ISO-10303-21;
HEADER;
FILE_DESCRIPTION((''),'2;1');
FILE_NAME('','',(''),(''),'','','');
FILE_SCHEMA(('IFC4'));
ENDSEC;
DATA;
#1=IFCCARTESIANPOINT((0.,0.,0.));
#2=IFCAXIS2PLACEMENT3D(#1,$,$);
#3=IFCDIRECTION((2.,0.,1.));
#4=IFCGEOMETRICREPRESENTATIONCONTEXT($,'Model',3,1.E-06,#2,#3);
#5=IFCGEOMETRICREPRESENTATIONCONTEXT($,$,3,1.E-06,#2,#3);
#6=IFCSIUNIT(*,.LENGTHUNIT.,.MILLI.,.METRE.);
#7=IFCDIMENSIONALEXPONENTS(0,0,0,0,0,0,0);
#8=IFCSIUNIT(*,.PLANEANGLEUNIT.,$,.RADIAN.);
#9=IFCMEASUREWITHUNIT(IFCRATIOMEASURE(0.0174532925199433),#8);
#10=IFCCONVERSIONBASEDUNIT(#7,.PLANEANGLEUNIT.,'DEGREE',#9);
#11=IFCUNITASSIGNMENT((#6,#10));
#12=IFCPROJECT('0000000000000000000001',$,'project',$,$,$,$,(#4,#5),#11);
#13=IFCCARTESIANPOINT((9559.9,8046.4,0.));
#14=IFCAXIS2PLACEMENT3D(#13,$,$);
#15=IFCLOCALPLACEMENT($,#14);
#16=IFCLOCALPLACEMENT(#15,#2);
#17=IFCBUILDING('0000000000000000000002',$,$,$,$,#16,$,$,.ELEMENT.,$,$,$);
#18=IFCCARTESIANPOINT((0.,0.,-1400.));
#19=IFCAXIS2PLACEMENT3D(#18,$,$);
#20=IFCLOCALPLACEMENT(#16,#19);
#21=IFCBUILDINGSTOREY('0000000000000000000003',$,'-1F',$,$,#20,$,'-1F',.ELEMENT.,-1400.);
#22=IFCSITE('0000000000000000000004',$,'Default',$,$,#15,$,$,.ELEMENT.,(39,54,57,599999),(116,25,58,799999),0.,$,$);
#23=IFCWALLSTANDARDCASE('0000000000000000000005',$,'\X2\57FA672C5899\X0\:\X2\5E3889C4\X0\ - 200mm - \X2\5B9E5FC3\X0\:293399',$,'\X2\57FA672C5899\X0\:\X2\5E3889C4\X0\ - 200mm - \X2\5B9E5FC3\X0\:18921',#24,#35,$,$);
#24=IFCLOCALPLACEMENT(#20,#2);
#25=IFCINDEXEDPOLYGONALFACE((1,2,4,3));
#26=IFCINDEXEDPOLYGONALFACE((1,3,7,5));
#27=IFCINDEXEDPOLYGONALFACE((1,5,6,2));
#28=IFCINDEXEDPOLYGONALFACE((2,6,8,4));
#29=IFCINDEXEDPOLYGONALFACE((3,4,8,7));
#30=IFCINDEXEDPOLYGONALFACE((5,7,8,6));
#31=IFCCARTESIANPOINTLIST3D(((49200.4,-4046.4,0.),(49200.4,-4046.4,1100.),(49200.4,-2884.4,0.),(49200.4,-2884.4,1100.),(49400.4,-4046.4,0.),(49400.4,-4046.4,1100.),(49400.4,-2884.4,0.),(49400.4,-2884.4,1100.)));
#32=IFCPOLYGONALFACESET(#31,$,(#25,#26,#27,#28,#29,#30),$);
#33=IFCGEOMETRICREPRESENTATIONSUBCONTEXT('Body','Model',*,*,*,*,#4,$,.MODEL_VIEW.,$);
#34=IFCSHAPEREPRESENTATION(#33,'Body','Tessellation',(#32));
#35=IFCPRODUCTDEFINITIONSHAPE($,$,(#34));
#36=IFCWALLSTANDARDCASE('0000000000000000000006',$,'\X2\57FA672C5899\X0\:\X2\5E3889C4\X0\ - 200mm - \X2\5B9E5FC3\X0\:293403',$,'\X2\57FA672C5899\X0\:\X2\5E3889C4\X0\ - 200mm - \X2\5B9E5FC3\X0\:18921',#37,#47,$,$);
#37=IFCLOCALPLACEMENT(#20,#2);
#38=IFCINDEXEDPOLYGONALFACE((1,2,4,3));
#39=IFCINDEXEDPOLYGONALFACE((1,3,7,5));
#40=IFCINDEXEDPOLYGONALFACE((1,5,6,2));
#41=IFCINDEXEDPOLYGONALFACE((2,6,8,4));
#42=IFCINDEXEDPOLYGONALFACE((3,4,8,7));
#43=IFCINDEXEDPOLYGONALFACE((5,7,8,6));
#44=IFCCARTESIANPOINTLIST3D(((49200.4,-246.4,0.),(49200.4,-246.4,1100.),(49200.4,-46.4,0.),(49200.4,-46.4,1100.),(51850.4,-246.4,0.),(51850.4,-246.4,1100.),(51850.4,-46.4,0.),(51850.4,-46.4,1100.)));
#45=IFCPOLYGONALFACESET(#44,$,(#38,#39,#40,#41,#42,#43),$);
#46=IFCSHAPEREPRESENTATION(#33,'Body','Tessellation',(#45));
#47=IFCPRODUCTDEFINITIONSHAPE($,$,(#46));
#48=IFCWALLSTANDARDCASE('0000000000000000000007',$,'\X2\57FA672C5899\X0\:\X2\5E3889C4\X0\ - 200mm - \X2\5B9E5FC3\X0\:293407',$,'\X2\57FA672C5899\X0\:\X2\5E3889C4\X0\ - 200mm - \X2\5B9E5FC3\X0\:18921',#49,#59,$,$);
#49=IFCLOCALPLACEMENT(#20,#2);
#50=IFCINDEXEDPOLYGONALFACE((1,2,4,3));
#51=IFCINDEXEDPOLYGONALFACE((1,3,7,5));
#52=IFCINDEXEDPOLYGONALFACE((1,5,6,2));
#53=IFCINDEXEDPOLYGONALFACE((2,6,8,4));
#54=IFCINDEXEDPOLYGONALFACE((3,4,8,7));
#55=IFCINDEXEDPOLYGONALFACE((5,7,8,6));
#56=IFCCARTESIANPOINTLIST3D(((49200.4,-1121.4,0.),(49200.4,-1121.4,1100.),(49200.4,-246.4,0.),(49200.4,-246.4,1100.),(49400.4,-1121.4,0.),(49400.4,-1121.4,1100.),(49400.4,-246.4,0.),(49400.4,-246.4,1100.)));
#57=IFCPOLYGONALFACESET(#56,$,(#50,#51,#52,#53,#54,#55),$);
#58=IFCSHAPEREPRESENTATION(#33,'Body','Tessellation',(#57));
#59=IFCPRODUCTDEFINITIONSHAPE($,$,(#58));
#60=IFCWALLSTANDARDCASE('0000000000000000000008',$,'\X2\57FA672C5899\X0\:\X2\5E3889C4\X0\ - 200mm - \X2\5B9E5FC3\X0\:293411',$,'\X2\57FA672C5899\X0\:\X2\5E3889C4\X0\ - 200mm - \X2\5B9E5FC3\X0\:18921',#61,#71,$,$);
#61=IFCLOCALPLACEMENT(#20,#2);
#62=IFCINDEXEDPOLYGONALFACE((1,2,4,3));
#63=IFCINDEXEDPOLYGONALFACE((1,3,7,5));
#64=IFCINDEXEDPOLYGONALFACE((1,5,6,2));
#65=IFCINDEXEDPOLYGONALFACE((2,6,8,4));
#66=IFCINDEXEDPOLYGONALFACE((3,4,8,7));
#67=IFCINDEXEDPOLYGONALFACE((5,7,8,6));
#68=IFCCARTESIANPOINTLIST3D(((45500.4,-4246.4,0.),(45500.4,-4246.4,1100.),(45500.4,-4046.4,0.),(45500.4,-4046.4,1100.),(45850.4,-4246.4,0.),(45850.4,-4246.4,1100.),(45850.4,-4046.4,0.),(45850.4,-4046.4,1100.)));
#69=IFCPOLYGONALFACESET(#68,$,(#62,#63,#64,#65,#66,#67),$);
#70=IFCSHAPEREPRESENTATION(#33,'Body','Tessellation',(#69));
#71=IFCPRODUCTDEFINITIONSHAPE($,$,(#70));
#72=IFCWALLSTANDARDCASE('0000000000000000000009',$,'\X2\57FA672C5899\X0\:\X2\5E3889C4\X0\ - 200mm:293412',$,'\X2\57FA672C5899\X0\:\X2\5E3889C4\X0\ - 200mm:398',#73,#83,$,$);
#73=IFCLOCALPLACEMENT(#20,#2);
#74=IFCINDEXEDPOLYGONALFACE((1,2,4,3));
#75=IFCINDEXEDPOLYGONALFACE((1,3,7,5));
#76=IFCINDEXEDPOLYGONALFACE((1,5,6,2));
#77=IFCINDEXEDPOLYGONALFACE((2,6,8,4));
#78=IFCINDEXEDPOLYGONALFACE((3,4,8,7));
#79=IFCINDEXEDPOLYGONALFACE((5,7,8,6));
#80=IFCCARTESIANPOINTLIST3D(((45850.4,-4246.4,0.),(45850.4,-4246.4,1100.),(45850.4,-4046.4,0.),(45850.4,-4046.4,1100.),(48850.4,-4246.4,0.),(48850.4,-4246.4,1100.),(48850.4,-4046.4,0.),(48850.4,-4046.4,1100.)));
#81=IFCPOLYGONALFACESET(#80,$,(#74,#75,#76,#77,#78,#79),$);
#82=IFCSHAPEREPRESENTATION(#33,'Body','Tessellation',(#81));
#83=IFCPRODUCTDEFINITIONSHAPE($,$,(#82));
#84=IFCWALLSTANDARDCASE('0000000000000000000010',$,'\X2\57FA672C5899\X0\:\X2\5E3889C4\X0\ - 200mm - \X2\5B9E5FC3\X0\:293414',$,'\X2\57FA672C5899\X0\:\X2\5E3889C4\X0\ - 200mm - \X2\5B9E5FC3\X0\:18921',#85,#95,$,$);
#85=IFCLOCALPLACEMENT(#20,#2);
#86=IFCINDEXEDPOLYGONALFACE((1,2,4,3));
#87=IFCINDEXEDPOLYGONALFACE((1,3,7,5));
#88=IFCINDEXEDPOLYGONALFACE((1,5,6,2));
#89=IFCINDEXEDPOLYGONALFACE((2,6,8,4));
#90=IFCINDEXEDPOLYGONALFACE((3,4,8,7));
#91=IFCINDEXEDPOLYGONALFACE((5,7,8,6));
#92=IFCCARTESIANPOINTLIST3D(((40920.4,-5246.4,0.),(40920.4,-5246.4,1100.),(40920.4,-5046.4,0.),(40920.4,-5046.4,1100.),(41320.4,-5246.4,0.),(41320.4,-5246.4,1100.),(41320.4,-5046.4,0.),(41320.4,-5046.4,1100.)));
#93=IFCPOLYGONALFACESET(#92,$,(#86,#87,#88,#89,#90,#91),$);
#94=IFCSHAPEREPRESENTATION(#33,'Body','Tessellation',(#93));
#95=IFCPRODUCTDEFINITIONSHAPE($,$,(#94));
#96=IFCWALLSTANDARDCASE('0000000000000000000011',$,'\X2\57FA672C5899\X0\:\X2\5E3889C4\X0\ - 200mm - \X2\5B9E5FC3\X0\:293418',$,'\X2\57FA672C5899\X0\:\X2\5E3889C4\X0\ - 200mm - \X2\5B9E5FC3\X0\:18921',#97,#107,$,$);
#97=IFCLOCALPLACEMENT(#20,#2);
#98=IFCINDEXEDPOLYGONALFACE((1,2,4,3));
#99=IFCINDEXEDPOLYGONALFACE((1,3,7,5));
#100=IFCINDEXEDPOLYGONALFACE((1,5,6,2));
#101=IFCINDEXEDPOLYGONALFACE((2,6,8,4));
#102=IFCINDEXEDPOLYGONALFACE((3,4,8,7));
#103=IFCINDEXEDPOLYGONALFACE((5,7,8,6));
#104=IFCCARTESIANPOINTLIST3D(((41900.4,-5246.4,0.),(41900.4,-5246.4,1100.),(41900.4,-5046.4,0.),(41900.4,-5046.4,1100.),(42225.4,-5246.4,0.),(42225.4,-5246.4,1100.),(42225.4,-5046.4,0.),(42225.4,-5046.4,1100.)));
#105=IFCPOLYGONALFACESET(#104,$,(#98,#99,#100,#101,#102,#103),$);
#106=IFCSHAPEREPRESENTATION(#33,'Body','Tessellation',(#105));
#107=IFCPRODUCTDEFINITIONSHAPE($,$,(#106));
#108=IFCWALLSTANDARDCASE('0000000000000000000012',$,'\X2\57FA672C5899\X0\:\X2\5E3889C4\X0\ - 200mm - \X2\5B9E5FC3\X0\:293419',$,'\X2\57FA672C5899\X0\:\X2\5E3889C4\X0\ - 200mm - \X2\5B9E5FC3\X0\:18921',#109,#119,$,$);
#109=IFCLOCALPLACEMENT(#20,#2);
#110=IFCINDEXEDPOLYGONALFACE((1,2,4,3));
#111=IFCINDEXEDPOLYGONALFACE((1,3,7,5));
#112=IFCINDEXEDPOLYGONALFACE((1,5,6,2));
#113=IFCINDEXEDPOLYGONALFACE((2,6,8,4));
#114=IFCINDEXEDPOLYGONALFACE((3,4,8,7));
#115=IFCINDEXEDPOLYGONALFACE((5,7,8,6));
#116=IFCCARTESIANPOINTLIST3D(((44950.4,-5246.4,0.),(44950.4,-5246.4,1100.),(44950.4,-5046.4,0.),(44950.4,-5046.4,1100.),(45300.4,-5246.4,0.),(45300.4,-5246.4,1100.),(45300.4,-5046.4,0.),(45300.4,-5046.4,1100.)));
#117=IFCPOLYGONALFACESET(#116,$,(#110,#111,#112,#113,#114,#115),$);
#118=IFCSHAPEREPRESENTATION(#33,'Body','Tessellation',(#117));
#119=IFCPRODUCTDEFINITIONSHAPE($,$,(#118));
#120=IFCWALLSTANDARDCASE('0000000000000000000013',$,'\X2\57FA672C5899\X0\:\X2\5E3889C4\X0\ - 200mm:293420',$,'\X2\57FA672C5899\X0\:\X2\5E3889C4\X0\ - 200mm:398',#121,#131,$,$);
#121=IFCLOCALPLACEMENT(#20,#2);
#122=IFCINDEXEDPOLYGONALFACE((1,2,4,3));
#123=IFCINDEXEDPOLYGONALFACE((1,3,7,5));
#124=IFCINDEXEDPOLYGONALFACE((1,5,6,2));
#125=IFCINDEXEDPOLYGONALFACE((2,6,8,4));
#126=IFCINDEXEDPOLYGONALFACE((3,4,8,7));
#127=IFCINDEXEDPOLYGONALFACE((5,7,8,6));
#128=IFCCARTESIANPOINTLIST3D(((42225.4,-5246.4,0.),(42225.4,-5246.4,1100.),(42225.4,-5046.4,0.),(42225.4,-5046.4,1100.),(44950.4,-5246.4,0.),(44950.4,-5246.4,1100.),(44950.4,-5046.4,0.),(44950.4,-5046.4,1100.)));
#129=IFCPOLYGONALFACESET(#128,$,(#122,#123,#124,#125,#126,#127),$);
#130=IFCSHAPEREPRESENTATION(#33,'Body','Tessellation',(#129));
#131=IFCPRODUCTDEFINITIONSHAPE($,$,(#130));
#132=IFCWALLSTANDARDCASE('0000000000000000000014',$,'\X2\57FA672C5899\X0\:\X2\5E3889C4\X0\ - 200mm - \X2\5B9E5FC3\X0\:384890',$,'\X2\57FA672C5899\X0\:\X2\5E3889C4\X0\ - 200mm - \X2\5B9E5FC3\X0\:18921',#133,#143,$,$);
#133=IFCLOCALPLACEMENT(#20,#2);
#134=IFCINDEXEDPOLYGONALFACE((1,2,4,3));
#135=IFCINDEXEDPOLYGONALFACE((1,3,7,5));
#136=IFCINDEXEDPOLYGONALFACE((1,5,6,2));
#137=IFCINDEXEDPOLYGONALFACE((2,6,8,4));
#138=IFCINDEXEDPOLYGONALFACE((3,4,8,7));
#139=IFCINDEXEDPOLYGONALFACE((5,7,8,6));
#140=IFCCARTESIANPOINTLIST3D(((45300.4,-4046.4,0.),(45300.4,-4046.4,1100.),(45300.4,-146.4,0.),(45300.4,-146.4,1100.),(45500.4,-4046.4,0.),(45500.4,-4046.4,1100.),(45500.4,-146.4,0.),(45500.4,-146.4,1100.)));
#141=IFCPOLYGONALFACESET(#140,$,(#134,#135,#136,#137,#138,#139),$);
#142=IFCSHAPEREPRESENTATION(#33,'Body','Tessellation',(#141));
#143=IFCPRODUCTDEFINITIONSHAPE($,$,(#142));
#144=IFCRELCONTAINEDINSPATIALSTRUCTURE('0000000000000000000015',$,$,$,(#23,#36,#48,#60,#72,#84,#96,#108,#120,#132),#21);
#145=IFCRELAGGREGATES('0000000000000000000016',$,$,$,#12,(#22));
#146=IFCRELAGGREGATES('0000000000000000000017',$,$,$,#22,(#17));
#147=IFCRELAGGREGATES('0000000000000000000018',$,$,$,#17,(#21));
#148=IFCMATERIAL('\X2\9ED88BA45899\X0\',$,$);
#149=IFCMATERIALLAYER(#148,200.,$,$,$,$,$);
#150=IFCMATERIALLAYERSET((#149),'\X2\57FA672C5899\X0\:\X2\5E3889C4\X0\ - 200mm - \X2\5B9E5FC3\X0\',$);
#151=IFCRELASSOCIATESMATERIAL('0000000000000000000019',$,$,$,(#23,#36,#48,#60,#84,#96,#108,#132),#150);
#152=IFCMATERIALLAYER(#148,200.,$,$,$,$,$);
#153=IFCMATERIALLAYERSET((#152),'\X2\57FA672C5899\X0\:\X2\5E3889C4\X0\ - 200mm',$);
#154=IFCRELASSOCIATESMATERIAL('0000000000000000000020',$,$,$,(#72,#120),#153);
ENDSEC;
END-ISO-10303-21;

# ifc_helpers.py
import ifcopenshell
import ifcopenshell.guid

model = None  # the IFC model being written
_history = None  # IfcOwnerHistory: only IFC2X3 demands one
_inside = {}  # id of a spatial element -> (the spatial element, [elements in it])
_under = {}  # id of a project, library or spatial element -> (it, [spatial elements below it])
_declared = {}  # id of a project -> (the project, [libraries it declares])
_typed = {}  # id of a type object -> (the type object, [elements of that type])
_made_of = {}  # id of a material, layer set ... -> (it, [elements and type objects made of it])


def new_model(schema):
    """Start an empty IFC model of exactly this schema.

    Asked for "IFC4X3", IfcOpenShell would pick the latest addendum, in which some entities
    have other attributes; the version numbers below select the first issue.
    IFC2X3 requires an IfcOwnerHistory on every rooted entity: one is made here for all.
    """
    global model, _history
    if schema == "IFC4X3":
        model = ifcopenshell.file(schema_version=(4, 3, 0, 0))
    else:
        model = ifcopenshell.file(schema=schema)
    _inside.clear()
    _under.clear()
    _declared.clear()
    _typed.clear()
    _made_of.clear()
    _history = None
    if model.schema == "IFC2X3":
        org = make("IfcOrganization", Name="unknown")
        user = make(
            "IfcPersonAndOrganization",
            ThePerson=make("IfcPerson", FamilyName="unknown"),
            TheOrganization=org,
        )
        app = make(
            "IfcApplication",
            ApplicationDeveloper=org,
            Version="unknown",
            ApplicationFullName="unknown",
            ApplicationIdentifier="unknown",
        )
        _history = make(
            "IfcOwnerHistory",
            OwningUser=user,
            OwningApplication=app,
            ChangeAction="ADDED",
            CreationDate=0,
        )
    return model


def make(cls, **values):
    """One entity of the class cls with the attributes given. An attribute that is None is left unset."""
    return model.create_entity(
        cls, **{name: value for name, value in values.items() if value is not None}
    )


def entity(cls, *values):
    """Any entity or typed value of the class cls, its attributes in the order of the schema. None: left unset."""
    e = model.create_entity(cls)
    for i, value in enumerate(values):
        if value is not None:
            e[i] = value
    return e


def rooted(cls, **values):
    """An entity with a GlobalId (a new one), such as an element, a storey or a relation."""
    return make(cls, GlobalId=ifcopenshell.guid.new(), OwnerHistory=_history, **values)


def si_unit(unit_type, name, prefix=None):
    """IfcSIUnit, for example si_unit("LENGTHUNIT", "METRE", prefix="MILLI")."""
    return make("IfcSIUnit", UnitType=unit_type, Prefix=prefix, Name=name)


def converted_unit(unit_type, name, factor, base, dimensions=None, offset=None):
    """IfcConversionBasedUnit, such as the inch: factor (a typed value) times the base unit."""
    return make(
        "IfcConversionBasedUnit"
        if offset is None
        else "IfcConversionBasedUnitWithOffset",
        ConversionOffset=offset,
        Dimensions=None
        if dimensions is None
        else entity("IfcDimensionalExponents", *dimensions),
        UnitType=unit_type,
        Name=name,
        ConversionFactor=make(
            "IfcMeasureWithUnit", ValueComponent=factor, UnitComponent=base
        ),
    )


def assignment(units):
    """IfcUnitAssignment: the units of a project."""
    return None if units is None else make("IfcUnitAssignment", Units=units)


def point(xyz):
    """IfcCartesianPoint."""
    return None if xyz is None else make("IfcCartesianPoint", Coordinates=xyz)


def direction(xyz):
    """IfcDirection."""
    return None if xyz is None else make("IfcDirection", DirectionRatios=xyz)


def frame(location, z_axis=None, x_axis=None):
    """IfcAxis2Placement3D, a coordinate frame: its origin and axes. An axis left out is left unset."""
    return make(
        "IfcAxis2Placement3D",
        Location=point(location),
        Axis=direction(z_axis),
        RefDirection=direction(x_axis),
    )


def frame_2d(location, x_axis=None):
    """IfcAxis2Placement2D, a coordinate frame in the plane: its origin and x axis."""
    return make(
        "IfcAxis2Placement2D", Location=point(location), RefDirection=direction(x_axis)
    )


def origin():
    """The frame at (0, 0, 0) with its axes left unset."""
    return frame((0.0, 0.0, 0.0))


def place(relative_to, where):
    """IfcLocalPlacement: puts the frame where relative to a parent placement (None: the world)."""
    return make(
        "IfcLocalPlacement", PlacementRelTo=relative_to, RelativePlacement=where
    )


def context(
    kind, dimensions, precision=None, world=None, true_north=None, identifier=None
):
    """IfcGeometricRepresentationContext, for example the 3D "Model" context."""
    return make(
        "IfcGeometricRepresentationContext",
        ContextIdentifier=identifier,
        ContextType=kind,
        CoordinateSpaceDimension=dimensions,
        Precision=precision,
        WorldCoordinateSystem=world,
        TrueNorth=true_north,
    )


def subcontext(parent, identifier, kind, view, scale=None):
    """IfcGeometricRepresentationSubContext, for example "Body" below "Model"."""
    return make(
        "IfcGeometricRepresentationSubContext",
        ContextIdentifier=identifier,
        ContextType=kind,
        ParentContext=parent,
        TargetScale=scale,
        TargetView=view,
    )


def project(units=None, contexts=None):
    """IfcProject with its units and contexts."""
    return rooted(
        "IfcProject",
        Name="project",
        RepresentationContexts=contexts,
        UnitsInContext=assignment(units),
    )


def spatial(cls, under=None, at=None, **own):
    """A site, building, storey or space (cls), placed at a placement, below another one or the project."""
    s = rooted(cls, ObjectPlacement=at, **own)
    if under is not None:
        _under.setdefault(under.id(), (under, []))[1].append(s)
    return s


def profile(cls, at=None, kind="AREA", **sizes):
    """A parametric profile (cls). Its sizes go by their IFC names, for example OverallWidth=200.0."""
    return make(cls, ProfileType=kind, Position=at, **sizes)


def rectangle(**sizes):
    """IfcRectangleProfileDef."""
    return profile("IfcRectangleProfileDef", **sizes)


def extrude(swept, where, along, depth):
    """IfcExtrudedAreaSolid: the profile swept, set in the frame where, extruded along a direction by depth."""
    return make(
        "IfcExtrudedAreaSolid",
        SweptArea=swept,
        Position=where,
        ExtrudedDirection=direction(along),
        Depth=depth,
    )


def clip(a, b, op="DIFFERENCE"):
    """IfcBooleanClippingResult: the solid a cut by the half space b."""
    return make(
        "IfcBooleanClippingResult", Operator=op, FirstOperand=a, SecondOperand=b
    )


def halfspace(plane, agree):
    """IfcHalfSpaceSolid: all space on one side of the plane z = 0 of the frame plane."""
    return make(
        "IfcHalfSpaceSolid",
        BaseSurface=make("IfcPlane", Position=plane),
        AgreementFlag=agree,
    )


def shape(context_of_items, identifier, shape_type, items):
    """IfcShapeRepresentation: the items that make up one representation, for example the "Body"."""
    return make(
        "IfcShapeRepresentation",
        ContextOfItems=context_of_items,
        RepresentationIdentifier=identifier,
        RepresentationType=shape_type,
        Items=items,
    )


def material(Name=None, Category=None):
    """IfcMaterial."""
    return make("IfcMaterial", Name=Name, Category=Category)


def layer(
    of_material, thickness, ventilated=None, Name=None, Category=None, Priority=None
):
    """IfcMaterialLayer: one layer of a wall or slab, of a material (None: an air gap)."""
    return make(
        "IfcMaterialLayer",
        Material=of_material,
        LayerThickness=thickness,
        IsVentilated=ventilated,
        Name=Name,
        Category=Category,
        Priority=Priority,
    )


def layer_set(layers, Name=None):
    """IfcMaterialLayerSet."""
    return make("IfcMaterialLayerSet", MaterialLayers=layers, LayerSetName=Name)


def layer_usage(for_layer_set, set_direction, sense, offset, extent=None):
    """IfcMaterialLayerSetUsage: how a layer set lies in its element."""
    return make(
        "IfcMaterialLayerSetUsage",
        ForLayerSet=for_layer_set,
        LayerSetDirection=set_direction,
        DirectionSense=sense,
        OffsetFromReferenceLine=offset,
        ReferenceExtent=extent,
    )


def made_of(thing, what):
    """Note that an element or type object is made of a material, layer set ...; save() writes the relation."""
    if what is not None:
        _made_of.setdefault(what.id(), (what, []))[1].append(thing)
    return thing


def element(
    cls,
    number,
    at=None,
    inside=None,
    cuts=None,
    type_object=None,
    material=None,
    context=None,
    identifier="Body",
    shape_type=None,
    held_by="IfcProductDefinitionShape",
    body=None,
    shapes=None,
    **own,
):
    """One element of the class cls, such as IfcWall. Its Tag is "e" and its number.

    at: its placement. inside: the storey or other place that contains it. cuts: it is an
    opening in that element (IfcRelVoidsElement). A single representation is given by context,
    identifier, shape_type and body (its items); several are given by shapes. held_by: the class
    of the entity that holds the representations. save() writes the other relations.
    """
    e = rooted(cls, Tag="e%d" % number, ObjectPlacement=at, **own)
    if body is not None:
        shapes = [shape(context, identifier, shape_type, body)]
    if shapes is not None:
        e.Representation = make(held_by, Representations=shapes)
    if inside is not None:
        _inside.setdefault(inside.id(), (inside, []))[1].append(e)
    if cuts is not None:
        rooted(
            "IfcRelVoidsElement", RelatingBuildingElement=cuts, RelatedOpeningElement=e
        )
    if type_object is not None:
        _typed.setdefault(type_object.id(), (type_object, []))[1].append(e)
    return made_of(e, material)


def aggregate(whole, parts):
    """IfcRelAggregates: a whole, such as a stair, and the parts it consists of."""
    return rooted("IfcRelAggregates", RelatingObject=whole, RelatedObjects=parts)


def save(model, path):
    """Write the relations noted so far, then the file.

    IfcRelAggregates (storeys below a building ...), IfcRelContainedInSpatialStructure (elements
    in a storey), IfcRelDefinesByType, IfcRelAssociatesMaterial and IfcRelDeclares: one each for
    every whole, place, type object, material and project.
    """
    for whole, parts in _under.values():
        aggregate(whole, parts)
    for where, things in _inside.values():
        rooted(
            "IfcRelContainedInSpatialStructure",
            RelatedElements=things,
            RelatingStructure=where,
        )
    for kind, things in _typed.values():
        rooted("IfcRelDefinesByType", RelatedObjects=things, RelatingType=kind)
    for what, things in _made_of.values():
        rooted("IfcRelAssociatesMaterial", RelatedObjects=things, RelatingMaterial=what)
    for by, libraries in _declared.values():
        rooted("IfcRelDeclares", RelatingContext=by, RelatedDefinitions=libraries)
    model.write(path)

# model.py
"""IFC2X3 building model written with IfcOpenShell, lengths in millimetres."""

from ifc_helpers import new_model, entity, si_unit, converted_unit, direction, frame, frame_2d, origin, place, context, subcontext, project, spatial, rectangle, extrude, clip, halfspace, material, layer, layer_set, layer_usage, element, save


model = new_model("IFC2X3")

# Units and contexts
model_context = context("Model", 3, precision=1e-06, world=origin(), true_north=direction((2.0, 0.0, 1.0)))
context_of_model = context(None, 3, precision=1e-06, world=origin(), true_north=direction((2.0, 0.0, 1.0)))
body_context = subcontext(model_context, "Body", "Model", "MODEL_VIEW")
ifc_project = project(units=[si_unit("LENGTHUNIT", "METRE", prefix="MILLI"), converted_unit("PLANEANGLEUNIT", "DEGREE", entity("IfcRatioMeasure", 0.0174532925199433), si_unit("PLANEANGLEUNIT", "RADIAN"), dimensions=[0, 0, 0, 0, 0, 0, 0])], contexts=[model_context, context_of_model])

# Site, building, storey
site_placement = place(None, frame((9559.9, 8046.4, 0.0)))
site = spatial("IfcSite", under=ifc_project, at=site_placement, Name="Default", CompositionType="ELEMENT", RefLatitude=(39, 54, 57, 599999), RefLongitude=(116, 25, 58, 799999), RefElevation=0.0)
building_placement = place(site_placement, origin())
building = spatial("IfcBuilding", under=site, at=building_placement, CompositionType="ELEMENT")
storey_placement = place(building_placement, frame((0.0, 0.0, -1400.0)))
storey = spatial("IfcBuildingStorey", under=building, at=storey_placement, Name="-1F", LongName="-1F", CompositionType="ELEMENT", Elevation=-1400.0)

# Walls
ifc_material = material(Name="默认墙")
ifc_layer_1 = layer(ifc_material, 200.0)
ifc_layer_set_1 = layer_set([ifc_layer_1], Name="基本墙:常规 - 200mm - 实心")
ifc_layer_2 = layer(ifc_material, 200.0)
ifc_layer_set_2 = layer_set([ifc_layer_2], Name="基本墙:常规 - 200mm")
ifc_layer_usage_1 = layer_usage(ifc_layer_set_1, "AXIS2", "NEGATIVE", 100.0)
wall_1_placement = place(storey_placement, frame((49300.4, -4046.4, 0.0), z_axis=(0.0, 0.0, 1.0), x_axis=(0.0, 1.0, 0.0)))
element("IfcWallStandardCase", 1, at=wall_1_placement, inside=storey, material=ifc_layer_usage_1, Name="基本墙:常规 - 200mm - 实心:293399", ObjectType="基本墙:常规 - 200mm - 实心:18921", context=body_context, shape_type="Clipping", body=[
    clip(extrude(rectangle(XDim=1162.0, YDim=200.0, at=frame_2d((581.0, 0.0), x_axis=(-1.0, 0.0))), origin(), (0.0, 0.0, 1.0), 1100.0), halfspace(origin(), True)),
])
ifc_layer_usage_2 = layer_usage(ifc_layer_set_1, "AXIS2", "NEGATIVE", 100.0)
wall_2_placement = place(storey_placement, frame((49200.4, -146.4, 0.0)))
element("IfcWallStandardCase", 2, at=wall_2_placement, inside=storey, material=ifc_layer_usage_2, Name="基本墙:常规 - 200mm - 实心:293403", ObjectType="基本墙:常规 - 200mm - 实心:18921", context=body_context, shape_type="Clipping", body=[
    clip(extrude(rectangle(XDim=2650.0, YDim=200.0, at=frame_2d((1325.0, 0.0), x_axis=(-1.0, 0.0))), origin(), (0.0, 0.0, 1.0), 1100.0), halfspace(origin(), True)),
])
ifc_layer_usage_3 = layer_usage(ifc_layer_set_1, "AXIS2", "NEGATIVE", 100.0)
wall_3_placement = place(storey_placement, frame((49300.4, -246.4, 0.0), z_axis=(0.0, 0.0, 1.0), x_axis=(0.0, -1.0, 0.0)))
element("IfcWallStandardCase", 3, at=wall_3_placement, inside=storey, material=ifc_layer_usage_3, Name="基本墙:常规 - 200mm - 实心:293407", ObjectType="基本墙:常规 - 200mm - 实心:18921", context=body_context, shape_type="Clipping", body=[
    clip(extrude(rectangle(XDim=875.0, YDim=200.0, at=frame_2d((437.5, 0.0), x_axis=(-1.0, 0.0))), origin(), (0.0, 0.0, 1.0), 1100.0), halfspace(origin(), True)),
])
ifc_layer_usage_4 = layer_usage(ifc_layer_set_1, "AXIS2", "NEGATIVE", 100.0)
wall_4_placement = place(storey_placement, frame((45500.4, -4146.4, 0.0)))
element("IfcWallStandardCase", 4, at=wall_4_placement, inside=storey, material=ifc_layer_usage_4, Name="基本墙:常规 - 200mm - 实心:293411", ObjectType="基本墙:常规 - 200mm - 实心:18921", context=body_context, shape_type="Clipping", body=[
    clip(extrude(rectangle(XDim=350.0, YDim=200.0, at=frame_2d((175.0, 0.0), x_axis=(-1.0, 0.0))), origin(), (0.0, 0.0, 1.0), 1100.0), halfspace(origin(), True)),
])
ifc_layer_usage_5 = layer_usage(ifc_layer_set_2, "AXIS2", "NEGATIVE", 100.0)
wall_5_placement = place(storey_placement, frame((45850.4, -4146.4, 0.0)))
element("IfcWallStandardCase", 5, at=wall_5_placement, inside=storey, material=ifc_layer_usage_5, Name="基本墙:常规 - 200mm:293412", ObjectType="基本墙:常规 - 200mm:398", context=body_context, shape_type="Clipping", body=[
    clip(extrude(rectangle(XDim=3000.0, YDim=200.0, at=frame_2d((1500.0, 0.0), x_axis=(-1.0, 0.0))), origin(), (0.0, 0.0, 1.0), 1100.0), halfspace(origin(), True)),
])
ifc_layer_usage_6 = layer_usage(ifc_layer_set_1, "AXIS2", "NEGATIVE", 100.0)
wall_6_placement = place(storey_placement, frame((41320.4, -5146.4, 0.0), z_axis=(0.0, 0.0, 1.0), x_axis=(-1.0, 0.0, 0.0)))
element("IfcWallStandardCase", 6, at=wall_6_placement, inside=storey, material=ifc_layer_usage_6, Name="基本墙:常规 - 200mm - 实心:293414", ObjectType="基本墙:常规 - 200mm - 实心:18921", context=body_context, shape_type="Clipping", body=[
    clip(extrude(rectangle(XDim=400.0, YDim=200.0, at=frame_2d((200.0, 0.0), x_axis=(-1.0, 0.0))), origin(), (0.0, 0.0, 1.0), 1100.0), halfspace(origin(), True)),
])
ifc_layer_usage_7 = layer_usage(ifc_layer_set_1, "AXIS2", "NEGATIVE", 100.0)
wall_7_placement = place(storey_placement, frame((41900.4, -5146.4, 0.0)))
element("IfcWallStandardCase", 7, at=wall_7_placement, inside=storey, material=ifc_layer_usage_7, Name="基本墙:常规 - 200mm - 实心:293418", ObjectType="基本墙:常规 - 200mm - 实心:18921", context=body_context, shape_type="Clipping", body=[
    clip(extrude(rectangle(XDim=325.0, YDim=200.0, at=frame_2d((162.5, 0.0), x_axis=(-1.0, 0.0))), origin(), (0.0, 0.0, 1.0), 1100.0), halfspace(origin(), True)),
])
ifc_layer_usage_8 = layer_usage(ifc_layer_set_1, "AXIS2", "NEGATIVE", 100.0)
wall_8_placement = place(storey_placement, frame((45300.4, -5146.4, 0.0), z_axis=(0.0, 0.0, 1.0), x_axis=(-1.0, 0.0, 0.0)))
element("IfcWallStandardCase", 8, at=wall_8_placement, inside=storey, material=ifc_layer_usage_8, Name="基本墙:常规 - 200mm - 实心:293419", ObjectType="基本墙:常规 - 200mm - 实心:18921", context=body_context, shape_type="Clipping", body=[
    clip(extrude(rectangle(XDim=350.0, YDim=200.0, at=frame_2d((175.0, 0.0), x_axis=(-1.0, 0.0))), origin(), (0.0, 0.0, 1.0), 1100.0), halfspace(origin(), True)),
])
ifc_layer_usage_9 = layer_usage(ifc_layer_set_2, "AXIS2", "NEGATIVE", 100.0)
wall_9_placement = place(storey_placement, frame((42225.4, -5146.4, 0.0)))
element("IfcWallStandardCase", 9, at=wall_9_placement, inside=storey, material=ifc_layer_usage_9, Name="基本墙:常规 - 200mm:293420", ObjectType="基本墙:常规 - 200mm:398", context=body_context, shape_type="Clipping", body=[
    clip(extrude(rectangle(XDim=2725.0, YDim=200.0, at=frame_2d((1362.5, 0.0), x_axis=(-1.0, 0.0))), origin(), (0.0, 0.0, 1.0), 1100.0), halfspace(origin(), True)),
])
ifc_layer_usage_10 = layer_usage(ifc_layer_set_1, "AXIS2", "NEGATIVE", 100.0)
wall_10_placement = place(storey_placement, frame((45400.4, -4046.4, 0.0), z_axis=(0.0, 0.0, 1.0), x_axis=(0.0, 1.0, 0.0)))
element("IfcWallStandardCase", 10, at=wall_10_placement, inside=storey, material=ifc_layer_usage_10, Name="基本墙:常规 - 200mm - 实心:384890", ObjectType="基本墙:常规 - 200mm - 实心:18921", context=body_context, shape_type="Clipping", body=[
    clip(extrude(rectangle(XDim=3900.0, YDim=200.0, at=frame_2d((1950.0, 0.0), x_axis=(-1.0, 0.0))), origin(), (0.0, 0.0, 1.0), 1100.0), halfspace(origin(), True)),
])

save(model, "model.ifc")
